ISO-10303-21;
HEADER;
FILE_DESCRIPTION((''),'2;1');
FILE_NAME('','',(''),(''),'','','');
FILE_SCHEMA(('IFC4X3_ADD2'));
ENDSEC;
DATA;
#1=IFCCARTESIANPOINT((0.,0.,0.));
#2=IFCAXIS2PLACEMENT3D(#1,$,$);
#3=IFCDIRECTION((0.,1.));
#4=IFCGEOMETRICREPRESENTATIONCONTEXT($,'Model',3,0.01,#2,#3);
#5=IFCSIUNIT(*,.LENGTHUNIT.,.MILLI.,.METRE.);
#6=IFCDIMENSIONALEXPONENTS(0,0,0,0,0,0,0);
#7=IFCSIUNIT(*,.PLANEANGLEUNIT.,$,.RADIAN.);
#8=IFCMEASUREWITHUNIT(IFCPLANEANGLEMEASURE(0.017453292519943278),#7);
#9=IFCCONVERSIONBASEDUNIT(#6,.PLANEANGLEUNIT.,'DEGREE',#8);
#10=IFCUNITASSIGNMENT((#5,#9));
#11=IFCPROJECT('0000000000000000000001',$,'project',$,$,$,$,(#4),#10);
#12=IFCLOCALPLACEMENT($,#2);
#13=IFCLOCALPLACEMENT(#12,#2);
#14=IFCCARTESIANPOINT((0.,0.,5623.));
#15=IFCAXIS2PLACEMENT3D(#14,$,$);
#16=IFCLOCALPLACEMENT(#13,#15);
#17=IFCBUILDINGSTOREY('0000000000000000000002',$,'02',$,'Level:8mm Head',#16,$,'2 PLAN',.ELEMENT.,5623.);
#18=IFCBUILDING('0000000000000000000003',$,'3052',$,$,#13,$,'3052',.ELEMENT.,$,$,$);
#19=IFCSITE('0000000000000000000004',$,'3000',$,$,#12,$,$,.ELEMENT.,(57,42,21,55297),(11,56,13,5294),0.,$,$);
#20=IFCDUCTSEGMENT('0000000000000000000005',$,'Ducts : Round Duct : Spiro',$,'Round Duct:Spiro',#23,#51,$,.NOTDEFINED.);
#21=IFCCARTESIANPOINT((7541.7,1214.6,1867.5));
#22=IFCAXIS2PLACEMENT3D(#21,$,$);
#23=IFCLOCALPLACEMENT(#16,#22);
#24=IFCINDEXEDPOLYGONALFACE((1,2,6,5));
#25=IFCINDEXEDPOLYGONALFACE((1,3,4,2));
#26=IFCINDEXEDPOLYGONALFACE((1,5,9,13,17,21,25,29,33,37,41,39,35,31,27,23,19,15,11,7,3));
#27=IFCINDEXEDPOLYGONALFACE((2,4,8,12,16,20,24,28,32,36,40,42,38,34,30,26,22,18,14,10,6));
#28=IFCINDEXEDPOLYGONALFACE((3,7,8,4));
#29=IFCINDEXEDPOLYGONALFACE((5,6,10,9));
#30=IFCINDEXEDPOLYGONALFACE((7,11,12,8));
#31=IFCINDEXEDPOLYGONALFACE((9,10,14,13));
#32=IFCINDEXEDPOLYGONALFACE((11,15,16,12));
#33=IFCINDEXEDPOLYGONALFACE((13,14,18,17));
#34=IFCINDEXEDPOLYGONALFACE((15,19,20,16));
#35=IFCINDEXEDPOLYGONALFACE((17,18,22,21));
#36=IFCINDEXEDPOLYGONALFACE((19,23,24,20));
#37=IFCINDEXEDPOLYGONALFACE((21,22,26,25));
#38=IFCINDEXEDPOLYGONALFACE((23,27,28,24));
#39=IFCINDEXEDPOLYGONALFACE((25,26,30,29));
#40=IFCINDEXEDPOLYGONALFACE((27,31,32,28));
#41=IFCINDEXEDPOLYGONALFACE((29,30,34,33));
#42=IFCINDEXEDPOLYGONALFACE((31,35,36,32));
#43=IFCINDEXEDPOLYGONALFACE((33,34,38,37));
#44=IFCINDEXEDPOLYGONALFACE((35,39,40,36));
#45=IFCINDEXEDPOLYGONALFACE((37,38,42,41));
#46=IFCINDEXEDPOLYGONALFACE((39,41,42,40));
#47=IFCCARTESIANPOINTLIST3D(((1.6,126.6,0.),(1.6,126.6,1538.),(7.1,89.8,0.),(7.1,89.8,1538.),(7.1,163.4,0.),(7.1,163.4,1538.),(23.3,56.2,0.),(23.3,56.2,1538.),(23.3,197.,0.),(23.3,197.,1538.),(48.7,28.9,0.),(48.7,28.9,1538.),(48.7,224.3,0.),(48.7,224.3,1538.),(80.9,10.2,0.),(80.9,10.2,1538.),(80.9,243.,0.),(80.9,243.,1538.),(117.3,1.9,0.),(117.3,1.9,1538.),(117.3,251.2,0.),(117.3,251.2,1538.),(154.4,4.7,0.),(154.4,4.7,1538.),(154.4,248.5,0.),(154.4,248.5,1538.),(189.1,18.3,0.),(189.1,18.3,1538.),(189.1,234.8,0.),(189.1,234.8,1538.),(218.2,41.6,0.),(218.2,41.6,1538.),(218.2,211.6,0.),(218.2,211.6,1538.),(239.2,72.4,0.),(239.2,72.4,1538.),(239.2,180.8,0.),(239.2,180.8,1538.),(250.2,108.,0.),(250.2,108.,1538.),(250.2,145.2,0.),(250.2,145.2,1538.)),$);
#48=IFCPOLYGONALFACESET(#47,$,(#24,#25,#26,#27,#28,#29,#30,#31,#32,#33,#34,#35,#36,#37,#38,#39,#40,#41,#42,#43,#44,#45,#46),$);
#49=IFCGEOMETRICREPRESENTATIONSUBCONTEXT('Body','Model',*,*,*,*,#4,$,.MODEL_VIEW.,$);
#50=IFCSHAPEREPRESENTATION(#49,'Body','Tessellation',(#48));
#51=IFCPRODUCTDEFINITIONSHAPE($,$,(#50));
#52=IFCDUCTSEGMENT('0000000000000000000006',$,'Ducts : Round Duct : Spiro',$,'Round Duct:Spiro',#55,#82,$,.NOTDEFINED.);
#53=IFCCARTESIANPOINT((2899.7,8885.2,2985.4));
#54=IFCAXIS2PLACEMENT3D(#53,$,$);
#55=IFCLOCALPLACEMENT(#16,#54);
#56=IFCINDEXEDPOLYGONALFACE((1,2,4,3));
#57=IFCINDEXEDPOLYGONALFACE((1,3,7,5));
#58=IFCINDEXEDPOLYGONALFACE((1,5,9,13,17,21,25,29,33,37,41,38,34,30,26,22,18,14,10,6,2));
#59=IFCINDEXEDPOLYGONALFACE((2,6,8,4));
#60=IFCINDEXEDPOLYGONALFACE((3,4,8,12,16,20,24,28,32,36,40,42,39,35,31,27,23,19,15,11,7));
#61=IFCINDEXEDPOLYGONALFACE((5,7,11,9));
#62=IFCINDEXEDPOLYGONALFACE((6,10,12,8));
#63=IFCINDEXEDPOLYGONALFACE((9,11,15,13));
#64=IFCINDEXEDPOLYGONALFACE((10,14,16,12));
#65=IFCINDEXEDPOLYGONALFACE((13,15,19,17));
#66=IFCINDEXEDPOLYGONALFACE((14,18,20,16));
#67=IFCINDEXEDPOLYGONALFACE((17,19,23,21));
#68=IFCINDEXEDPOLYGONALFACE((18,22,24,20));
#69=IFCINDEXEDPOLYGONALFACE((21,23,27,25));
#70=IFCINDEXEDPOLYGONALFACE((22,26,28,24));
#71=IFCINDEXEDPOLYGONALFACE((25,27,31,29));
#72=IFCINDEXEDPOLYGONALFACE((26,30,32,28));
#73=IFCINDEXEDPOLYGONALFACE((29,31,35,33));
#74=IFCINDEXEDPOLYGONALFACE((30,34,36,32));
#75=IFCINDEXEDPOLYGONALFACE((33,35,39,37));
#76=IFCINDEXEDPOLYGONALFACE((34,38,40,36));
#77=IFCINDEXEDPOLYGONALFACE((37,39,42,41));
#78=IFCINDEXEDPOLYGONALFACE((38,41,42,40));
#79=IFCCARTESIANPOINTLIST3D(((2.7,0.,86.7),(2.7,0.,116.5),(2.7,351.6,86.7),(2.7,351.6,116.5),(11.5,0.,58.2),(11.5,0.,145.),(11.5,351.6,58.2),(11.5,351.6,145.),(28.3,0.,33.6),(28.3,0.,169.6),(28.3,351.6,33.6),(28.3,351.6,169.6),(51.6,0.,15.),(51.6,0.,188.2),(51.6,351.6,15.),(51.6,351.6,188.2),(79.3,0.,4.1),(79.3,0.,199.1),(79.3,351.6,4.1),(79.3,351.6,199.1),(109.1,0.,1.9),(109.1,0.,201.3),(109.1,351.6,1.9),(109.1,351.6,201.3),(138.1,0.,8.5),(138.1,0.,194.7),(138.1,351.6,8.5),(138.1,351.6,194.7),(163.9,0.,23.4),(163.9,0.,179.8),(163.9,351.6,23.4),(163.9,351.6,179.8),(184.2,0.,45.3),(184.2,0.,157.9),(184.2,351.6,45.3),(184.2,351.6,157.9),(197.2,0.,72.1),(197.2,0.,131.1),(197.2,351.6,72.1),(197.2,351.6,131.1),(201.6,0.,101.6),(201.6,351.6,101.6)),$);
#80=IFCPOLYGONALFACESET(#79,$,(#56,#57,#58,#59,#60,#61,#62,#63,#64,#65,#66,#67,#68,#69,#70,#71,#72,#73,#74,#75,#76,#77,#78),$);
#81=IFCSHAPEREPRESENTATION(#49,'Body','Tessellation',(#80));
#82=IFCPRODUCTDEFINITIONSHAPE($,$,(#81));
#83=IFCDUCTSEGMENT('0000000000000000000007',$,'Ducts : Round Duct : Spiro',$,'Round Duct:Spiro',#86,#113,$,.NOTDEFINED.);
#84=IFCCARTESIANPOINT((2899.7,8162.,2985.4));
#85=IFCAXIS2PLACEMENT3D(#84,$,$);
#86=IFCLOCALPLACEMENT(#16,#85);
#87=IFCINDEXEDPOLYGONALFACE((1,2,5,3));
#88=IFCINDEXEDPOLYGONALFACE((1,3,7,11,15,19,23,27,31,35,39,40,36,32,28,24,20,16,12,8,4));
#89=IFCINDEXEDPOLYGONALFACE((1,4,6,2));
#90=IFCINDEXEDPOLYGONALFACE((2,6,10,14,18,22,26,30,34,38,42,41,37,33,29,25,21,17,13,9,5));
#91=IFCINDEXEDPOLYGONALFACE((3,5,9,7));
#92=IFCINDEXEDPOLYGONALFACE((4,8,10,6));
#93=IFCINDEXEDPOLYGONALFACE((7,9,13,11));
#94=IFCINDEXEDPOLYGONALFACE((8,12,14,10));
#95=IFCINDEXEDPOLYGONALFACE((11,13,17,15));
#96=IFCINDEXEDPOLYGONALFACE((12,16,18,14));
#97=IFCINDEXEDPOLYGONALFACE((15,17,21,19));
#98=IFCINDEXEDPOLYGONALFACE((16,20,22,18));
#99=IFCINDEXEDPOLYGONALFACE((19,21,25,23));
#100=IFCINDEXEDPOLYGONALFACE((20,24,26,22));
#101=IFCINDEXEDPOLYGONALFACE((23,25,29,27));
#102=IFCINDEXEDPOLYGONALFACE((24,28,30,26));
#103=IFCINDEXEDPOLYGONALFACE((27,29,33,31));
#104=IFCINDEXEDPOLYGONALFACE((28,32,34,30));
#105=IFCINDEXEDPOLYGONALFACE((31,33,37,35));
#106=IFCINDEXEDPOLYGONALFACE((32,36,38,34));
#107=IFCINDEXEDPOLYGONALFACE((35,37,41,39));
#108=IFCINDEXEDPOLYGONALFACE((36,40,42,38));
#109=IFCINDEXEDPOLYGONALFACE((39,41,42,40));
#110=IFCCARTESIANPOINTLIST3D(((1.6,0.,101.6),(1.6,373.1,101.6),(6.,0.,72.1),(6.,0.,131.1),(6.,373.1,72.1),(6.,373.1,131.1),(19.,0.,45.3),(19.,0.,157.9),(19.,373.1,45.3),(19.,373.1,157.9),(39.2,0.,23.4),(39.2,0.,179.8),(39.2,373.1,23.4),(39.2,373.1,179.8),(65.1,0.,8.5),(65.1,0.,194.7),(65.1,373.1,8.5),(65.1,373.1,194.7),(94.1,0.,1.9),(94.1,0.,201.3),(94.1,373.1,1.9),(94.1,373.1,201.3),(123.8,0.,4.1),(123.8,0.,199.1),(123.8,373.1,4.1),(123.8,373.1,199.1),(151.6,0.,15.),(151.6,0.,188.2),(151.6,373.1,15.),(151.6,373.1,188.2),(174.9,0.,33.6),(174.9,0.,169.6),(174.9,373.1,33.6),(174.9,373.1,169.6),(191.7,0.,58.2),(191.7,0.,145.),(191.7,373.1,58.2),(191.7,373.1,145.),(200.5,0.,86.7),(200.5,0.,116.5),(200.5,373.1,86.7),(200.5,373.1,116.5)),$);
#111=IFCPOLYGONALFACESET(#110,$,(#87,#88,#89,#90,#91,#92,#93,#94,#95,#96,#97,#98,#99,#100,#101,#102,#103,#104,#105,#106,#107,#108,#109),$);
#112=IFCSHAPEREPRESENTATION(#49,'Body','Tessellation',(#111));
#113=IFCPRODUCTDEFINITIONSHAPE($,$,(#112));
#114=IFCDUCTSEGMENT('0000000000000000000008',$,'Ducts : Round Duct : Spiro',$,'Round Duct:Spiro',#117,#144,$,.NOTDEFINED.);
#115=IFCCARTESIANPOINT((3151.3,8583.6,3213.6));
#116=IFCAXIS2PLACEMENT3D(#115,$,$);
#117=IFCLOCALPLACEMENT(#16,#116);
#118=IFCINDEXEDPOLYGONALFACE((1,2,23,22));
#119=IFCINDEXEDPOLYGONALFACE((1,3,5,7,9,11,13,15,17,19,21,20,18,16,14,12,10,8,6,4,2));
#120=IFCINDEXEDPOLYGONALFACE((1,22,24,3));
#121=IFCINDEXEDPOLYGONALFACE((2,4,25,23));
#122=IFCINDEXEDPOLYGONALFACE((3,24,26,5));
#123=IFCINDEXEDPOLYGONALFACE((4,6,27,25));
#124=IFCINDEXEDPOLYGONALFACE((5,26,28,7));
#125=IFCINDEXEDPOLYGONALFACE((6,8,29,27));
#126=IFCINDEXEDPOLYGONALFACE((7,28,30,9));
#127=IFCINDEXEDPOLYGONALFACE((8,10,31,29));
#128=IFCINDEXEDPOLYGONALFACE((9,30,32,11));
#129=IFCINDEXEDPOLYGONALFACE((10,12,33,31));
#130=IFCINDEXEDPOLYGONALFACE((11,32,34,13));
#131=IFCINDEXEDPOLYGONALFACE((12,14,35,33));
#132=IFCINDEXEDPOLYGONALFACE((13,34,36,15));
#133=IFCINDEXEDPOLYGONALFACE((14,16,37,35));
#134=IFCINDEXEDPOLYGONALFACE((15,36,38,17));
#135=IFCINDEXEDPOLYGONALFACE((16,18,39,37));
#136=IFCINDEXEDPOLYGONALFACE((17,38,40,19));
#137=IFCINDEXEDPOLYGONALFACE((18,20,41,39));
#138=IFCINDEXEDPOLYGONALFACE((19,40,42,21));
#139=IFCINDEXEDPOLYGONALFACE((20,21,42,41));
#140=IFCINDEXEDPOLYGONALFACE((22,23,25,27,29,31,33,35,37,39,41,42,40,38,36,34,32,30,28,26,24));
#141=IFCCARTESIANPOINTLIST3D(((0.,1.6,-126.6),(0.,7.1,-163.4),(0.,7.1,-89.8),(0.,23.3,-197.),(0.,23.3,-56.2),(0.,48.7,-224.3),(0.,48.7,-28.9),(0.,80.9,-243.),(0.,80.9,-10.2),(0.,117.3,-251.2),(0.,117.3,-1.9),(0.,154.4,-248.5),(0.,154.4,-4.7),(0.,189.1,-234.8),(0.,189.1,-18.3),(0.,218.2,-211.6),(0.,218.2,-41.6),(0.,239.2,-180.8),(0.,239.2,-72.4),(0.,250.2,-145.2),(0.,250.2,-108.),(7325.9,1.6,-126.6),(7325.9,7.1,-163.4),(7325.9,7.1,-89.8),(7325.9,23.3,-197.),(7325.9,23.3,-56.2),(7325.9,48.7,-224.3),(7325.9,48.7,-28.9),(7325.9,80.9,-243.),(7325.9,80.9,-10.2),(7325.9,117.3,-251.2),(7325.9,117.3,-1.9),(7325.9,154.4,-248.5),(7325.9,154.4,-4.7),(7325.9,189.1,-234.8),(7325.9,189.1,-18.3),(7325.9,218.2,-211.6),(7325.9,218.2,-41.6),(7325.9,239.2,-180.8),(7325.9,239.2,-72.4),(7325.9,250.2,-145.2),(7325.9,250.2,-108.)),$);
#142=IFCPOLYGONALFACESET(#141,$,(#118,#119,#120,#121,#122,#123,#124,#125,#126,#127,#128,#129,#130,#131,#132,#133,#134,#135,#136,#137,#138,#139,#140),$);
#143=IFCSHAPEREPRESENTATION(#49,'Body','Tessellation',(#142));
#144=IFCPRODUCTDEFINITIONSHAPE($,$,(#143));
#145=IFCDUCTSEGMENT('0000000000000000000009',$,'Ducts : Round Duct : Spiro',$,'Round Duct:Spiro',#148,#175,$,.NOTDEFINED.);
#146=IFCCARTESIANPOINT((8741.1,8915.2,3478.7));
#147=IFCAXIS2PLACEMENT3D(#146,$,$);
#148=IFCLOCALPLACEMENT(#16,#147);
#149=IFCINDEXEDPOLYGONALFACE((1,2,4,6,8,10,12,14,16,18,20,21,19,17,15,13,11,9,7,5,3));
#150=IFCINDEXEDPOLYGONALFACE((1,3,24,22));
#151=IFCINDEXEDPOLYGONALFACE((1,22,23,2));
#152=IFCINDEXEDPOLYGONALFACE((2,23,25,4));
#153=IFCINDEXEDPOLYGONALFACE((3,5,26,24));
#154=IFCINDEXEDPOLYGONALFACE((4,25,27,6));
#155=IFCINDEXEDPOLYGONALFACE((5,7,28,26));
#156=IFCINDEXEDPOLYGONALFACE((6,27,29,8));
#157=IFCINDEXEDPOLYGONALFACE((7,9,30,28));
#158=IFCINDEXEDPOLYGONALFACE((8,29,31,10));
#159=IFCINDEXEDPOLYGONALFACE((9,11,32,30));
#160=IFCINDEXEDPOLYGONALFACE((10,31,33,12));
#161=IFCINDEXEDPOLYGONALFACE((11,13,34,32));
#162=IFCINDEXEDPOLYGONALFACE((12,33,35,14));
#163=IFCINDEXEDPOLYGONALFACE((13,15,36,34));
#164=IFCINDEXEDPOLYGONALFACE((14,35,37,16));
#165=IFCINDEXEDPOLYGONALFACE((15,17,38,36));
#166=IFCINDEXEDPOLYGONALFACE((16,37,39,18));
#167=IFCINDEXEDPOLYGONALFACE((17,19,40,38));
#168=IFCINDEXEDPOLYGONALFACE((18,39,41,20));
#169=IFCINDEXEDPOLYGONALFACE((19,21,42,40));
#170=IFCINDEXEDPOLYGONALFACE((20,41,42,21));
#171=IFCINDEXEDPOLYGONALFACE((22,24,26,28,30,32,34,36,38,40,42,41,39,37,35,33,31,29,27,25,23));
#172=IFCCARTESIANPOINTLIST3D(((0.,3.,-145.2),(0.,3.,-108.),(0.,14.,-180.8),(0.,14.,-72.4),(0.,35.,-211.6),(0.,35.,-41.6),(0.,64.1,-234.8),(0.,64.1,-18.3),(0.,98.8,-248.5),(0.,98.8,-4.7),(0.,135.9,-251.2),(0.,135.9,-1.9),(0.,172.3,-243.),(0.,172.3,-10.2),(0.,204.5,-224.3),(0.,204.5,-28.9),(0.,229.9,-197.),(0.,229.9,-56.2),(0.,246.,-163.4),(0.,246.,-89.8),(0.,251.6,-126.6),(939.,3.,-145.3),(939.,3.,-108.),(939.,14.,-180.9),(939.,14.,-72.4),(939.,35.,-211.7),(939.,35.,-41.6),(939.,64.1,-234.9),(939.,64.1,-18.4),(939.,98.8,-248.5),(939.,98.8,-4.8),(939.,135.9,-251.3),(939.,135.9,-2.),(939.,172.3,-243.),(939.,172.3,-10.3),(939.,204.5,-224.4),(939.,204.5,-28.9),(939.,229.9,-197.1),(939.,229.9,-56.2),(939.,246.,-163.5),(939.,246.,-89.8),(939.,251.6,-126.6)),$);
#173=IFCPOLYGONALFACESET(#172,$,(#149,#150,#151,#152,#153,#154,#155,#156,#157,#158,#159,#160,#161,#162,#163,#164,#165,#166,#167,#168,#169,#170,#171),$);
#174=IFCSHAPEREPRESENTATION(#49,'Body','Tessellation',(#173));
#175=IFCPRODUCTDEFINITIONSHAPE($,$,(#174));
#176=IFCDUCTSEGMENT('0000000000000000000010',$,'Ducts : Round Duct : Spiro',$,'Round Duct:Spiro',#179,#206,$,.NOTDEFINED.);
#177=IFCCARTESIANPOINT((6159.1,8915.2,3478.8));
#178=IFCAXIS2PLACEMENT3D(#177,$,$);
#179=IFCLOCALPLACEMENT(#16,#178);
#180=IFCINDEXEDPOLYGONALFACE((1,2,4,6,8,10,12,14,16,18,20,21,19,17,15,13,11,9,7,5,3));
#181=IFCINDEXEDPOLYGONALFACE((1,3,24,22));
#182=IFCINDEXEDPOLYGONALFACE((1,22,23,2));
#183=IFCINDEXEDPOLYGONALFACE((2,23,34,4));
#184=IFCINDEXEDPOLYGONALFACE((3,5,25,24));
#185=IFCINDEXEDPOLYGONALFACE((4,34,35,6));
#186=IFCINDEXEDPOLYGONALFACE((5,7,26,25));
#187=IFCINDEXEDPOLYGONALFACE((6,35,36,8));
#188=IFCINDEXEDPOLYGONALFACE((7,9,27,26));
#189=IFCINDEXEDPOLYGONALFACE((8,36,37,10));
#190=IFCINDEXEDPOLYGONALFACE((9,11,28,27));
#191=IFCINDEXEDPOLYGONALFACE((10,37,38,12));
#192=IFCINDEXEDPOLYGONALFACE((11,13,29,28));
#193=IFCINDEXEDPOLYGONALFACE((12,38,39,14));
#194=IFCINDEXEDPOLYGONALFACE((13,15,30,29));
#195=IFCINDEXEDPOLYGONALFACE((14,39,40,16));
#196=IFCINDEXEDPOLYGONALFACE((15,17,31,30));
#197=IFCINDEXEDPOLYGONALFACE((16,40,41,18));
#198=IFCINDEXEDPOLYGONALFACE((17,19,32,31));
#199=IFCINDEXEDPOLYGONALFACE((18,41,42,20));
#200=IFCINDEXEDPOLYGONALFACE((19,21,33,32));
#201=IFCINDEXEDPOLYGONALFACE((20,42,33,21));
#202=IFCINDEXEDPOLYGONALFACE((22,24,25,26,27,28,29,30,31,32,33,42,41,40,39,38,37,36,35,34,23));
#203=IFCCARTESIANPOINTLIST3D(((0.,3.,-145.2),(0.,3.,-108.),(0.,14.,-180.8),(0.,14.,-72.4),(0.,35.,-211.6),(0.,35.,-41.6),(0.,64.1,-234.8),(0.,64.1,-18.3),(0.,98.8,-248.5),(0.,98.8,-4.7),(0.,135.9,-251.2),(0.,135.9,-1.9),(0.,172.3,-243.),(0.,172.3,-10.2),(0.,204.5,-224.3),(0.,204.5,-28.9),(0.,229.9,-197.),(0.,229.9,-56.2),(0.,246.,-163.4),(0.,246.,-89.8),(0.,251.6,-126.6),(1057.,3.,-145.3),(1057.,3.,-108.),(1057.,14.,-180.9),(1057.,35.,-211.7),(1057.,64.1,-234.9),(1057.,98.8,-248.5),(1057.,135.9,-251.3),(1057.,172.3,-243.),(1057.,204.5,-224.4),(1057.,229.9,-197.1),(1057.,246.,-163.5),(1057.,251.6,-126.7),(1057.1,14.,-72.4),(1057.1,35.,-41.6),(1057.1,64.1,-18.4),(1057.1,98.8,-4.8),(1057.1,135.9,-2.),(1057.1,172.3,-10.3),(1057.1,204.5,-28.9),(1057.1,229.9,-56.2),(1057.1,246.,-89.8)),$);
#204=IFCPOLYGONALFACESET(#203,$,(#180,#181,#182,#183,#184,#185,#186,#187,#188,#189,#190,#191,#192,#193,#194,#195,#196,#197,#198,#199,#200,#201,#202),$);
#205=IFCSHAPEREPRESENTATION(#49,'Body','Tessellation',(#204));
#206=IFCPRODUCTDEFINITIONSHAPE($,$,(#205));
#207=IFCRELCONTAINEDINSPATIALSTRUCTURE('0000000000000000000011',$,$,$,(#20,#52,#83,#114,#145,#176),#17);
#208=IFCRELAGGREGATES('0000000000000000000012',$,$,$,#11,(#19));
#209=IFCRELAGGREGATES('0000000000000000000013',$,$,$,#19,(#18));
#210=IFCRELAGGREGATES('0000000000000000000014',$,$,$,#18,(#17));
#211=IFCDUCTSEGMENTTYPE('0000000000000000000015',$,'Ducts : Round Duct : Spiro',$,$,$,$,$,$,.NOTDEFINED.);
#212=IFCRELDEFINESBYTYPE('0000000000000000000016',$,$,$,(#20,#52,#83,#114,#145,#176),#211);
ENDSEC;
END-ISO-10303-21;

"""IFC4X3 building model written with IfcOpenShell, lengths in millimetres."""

from ifc_helpers import new_model, entity, si_unit, converted_unit, direction, frame, frame_2d, origin, place, context, subcontext, project, spatial, circle, extrude, type_object, element, save


model = new_model("IFC4X3")

# Units and contexts
model_context = context("Model", 3, precision=0.01, world=origin(), true_north=direction((0.0, 1.0)))
body_context = subcontext(model_context, "Body", "Model", "MODEL_VIEW")
ifc_project = project(units=[si_unit("LENGTHUNIT", "METRE", prefix="MILLI"), converted_unit("PLANEANGLEUNIT", "DEGREE", entity("IfcPlaneAngleMeasure", 0.017453292519943278), si_unit("PLANEANGLEUNIT", "RADIAN"), dimensions=[0, 0, 0, 0, 0, 0, 0])], contexts=[model_context])

# Site, building, storey
site_placement = place(None, origin())
site = spatial("IfcSite", under=ifc_project, at=site_placement, Name="3000", CompositionType="ELEMENT", RefLatitude=(57, 42, 21, 55297), RefLongitude=(11, 56, 13, 5294), RefElevation=0.0)
building_placement = place(site_placement, origin())
building = spatial("IfcBuilding", under=site, at=building_placement, Name="3052", LongName="3052", CompositionType="ELEMENT")
storey_placement = place(building_placement, frame((0.0, 0.0, 5623.0)))
storey = spatial("IfcBuildingStorey", under=building, at=storey_placement, Name="02", ObjectType="Level:8mm Head", LongName="2 PLAN", CompositionType="ELEMENT", Elevation=5623.0)

# Duct segments
duct_segment_type = type_object("IfcDuctSegmentType", Name="Ducts : Round Duct : Spiro", PredefinedType="NOTDEFINED")
duct_segment_1_placement = place(storey_placement, frame((7541.7, 1214.6, 1867.5)))
element("IfcDuctSegment", 1, at=duct_segment_1_placement, inside=storey, type_object=duct_segment_type, Name="Ducts : Round Duct : Spiro", ObjectType="Round Duct:Spiro", PredefinedType="NOTDEFINED", context=body_context, shape_type="SweptSolid", body=[
    extrude(circle(Radius=125.0, at=frame_2d((0.0, 0.0), x_axis=(1.0, 0.0))), frame((126.6, 126.6, 0.0), z_axis=(0.0, 0.0, 1.0), x_axis=(-1.0, 0.0, 0.0)), (0.0, 0.0, 1.0), 1538.0),
])
duct_segment_2_placement = place(storey_placement, frame((2899.7, 8885.2, 2985.4)))
element("IfcDuctSegment", 2, at=duct_segment_2_placement, inside=storey, type_object=duct_segment_type, Name="Ducts : Round Duct : Spiro", ObjectType="Round Duct:Spiro", PredefinedType="NOTDEFINED", context=body_context, shape_type="SweptSolid", body=[
    extrude(circle(Radius=100.0, at=frame_2d((0.0, 0.0), x_axis=(1.0, 0.0))), frame((101.6, 0.0, 101.6), z_axis=(0.0, 1.0, 0.0), x_axis=(1.0, 0.0, 0.0)), (0.0, 0.0, 1.0), 351.6),
])
duct_segment_3_placement = place(storey_placement, frame((2899.7, 8162.0, 2985.4)))
element("IfcDuctSegment", 3, at=duct_segment_3_placement, inside=storey, type_object=duct_segment_type, Name="Ducts : Round Duct : Spiro", ObjectType="Round Duct:Spiro", PredefinedType="NOTDEFINED", context=body_context, shape_type="SweptSolid", body=[
    extrude(circle(Radius=100.0, at=frame_2d((0.0, 0.0), x_axis=(1.0, 0.0))), frame((101.6, 0.0, 101.6), z_axis=(0.0, 1.0, 0.0), x_axis=(-1.0, 0.0, 0.0)), (0.0, 0.0, 1.0), 373.1),
])
duct_segment_4_placement = place(storey_placement, frame((3151.3, 8583.6, 3213.6)))
element("IfcDuctSegment", 4, at=duct_segment_4_placement, inside=storey, type_object=duct_segment_type, Name="Ducts : Round Duct : Spiro", ObjectType="Round Duct:Spiro", PredefinedType="NOTDEFINED", context=body_context, shape_type="SweptSolid", body=[
    extrude(circle(Radius=125.0, at=frame_2d((0.0, 0.0), x_axis=(1.0, 0.0))), frame((0.0, 126.6, -126.6), z_axis=(1.0, 0.0, 0.0), x_axis=(0.0, -1.0, 0.0)), (0.0, 0.0, 1.0), 7325.9),
])
duct_segment_5_placement = place(storey_placement, frame((8741.1, 8915.2, 3478.7)))
element("IfcDuctSegment", 5, at=duct_segment_5_placement, inside=storey, type_object=duct_segment_type, Name="Ducts : Round Duct : Spiro", ObjectType="Round Duct:Spiro", PredefinedType="NOTDEFINED", context=body_context, shape_type="SweptSolid", body=[
    extrude(circle(Radius=125.0, at=frame_2d((0.0, 0.0), x_axis=(1.0, 0.0))), frame((939.0, 126.6, -126.6), z_axis=(-1.0, 0.0, 0.000055), x_axis=(0.0, 1.0, 0.0)), (0.0, 0.0, 1.0), 939.0),
])
duct_segment_6_placement = place(storey_placement, frame((6159.1, 8915.2, 3478.8)))
element("IfcDuctSegment", 6, at=duct_segment_6_placement, inside=storey, type_object=duct_segment_type, Name="Ducts : Round Duct : Spiro", ObjectType="Round Duct:Spiro", PredefinedType="NOTDEFINED", context=body_context, shape_type="SweptSolid", body=[
    extrude(circle(Radius=125.0, at=frame_2d((0.0, 0.0), x_axis=(1.0, 0.0))), frame((1057.0, 126.6, -126.7), z_axis=(-1.0, 0.0, 0.000055), x_axis=(0.0, 1.0, 0.0)), (0.0, 0.0, 1.0), 1057.0),
])

save(model, "model.ifc")
